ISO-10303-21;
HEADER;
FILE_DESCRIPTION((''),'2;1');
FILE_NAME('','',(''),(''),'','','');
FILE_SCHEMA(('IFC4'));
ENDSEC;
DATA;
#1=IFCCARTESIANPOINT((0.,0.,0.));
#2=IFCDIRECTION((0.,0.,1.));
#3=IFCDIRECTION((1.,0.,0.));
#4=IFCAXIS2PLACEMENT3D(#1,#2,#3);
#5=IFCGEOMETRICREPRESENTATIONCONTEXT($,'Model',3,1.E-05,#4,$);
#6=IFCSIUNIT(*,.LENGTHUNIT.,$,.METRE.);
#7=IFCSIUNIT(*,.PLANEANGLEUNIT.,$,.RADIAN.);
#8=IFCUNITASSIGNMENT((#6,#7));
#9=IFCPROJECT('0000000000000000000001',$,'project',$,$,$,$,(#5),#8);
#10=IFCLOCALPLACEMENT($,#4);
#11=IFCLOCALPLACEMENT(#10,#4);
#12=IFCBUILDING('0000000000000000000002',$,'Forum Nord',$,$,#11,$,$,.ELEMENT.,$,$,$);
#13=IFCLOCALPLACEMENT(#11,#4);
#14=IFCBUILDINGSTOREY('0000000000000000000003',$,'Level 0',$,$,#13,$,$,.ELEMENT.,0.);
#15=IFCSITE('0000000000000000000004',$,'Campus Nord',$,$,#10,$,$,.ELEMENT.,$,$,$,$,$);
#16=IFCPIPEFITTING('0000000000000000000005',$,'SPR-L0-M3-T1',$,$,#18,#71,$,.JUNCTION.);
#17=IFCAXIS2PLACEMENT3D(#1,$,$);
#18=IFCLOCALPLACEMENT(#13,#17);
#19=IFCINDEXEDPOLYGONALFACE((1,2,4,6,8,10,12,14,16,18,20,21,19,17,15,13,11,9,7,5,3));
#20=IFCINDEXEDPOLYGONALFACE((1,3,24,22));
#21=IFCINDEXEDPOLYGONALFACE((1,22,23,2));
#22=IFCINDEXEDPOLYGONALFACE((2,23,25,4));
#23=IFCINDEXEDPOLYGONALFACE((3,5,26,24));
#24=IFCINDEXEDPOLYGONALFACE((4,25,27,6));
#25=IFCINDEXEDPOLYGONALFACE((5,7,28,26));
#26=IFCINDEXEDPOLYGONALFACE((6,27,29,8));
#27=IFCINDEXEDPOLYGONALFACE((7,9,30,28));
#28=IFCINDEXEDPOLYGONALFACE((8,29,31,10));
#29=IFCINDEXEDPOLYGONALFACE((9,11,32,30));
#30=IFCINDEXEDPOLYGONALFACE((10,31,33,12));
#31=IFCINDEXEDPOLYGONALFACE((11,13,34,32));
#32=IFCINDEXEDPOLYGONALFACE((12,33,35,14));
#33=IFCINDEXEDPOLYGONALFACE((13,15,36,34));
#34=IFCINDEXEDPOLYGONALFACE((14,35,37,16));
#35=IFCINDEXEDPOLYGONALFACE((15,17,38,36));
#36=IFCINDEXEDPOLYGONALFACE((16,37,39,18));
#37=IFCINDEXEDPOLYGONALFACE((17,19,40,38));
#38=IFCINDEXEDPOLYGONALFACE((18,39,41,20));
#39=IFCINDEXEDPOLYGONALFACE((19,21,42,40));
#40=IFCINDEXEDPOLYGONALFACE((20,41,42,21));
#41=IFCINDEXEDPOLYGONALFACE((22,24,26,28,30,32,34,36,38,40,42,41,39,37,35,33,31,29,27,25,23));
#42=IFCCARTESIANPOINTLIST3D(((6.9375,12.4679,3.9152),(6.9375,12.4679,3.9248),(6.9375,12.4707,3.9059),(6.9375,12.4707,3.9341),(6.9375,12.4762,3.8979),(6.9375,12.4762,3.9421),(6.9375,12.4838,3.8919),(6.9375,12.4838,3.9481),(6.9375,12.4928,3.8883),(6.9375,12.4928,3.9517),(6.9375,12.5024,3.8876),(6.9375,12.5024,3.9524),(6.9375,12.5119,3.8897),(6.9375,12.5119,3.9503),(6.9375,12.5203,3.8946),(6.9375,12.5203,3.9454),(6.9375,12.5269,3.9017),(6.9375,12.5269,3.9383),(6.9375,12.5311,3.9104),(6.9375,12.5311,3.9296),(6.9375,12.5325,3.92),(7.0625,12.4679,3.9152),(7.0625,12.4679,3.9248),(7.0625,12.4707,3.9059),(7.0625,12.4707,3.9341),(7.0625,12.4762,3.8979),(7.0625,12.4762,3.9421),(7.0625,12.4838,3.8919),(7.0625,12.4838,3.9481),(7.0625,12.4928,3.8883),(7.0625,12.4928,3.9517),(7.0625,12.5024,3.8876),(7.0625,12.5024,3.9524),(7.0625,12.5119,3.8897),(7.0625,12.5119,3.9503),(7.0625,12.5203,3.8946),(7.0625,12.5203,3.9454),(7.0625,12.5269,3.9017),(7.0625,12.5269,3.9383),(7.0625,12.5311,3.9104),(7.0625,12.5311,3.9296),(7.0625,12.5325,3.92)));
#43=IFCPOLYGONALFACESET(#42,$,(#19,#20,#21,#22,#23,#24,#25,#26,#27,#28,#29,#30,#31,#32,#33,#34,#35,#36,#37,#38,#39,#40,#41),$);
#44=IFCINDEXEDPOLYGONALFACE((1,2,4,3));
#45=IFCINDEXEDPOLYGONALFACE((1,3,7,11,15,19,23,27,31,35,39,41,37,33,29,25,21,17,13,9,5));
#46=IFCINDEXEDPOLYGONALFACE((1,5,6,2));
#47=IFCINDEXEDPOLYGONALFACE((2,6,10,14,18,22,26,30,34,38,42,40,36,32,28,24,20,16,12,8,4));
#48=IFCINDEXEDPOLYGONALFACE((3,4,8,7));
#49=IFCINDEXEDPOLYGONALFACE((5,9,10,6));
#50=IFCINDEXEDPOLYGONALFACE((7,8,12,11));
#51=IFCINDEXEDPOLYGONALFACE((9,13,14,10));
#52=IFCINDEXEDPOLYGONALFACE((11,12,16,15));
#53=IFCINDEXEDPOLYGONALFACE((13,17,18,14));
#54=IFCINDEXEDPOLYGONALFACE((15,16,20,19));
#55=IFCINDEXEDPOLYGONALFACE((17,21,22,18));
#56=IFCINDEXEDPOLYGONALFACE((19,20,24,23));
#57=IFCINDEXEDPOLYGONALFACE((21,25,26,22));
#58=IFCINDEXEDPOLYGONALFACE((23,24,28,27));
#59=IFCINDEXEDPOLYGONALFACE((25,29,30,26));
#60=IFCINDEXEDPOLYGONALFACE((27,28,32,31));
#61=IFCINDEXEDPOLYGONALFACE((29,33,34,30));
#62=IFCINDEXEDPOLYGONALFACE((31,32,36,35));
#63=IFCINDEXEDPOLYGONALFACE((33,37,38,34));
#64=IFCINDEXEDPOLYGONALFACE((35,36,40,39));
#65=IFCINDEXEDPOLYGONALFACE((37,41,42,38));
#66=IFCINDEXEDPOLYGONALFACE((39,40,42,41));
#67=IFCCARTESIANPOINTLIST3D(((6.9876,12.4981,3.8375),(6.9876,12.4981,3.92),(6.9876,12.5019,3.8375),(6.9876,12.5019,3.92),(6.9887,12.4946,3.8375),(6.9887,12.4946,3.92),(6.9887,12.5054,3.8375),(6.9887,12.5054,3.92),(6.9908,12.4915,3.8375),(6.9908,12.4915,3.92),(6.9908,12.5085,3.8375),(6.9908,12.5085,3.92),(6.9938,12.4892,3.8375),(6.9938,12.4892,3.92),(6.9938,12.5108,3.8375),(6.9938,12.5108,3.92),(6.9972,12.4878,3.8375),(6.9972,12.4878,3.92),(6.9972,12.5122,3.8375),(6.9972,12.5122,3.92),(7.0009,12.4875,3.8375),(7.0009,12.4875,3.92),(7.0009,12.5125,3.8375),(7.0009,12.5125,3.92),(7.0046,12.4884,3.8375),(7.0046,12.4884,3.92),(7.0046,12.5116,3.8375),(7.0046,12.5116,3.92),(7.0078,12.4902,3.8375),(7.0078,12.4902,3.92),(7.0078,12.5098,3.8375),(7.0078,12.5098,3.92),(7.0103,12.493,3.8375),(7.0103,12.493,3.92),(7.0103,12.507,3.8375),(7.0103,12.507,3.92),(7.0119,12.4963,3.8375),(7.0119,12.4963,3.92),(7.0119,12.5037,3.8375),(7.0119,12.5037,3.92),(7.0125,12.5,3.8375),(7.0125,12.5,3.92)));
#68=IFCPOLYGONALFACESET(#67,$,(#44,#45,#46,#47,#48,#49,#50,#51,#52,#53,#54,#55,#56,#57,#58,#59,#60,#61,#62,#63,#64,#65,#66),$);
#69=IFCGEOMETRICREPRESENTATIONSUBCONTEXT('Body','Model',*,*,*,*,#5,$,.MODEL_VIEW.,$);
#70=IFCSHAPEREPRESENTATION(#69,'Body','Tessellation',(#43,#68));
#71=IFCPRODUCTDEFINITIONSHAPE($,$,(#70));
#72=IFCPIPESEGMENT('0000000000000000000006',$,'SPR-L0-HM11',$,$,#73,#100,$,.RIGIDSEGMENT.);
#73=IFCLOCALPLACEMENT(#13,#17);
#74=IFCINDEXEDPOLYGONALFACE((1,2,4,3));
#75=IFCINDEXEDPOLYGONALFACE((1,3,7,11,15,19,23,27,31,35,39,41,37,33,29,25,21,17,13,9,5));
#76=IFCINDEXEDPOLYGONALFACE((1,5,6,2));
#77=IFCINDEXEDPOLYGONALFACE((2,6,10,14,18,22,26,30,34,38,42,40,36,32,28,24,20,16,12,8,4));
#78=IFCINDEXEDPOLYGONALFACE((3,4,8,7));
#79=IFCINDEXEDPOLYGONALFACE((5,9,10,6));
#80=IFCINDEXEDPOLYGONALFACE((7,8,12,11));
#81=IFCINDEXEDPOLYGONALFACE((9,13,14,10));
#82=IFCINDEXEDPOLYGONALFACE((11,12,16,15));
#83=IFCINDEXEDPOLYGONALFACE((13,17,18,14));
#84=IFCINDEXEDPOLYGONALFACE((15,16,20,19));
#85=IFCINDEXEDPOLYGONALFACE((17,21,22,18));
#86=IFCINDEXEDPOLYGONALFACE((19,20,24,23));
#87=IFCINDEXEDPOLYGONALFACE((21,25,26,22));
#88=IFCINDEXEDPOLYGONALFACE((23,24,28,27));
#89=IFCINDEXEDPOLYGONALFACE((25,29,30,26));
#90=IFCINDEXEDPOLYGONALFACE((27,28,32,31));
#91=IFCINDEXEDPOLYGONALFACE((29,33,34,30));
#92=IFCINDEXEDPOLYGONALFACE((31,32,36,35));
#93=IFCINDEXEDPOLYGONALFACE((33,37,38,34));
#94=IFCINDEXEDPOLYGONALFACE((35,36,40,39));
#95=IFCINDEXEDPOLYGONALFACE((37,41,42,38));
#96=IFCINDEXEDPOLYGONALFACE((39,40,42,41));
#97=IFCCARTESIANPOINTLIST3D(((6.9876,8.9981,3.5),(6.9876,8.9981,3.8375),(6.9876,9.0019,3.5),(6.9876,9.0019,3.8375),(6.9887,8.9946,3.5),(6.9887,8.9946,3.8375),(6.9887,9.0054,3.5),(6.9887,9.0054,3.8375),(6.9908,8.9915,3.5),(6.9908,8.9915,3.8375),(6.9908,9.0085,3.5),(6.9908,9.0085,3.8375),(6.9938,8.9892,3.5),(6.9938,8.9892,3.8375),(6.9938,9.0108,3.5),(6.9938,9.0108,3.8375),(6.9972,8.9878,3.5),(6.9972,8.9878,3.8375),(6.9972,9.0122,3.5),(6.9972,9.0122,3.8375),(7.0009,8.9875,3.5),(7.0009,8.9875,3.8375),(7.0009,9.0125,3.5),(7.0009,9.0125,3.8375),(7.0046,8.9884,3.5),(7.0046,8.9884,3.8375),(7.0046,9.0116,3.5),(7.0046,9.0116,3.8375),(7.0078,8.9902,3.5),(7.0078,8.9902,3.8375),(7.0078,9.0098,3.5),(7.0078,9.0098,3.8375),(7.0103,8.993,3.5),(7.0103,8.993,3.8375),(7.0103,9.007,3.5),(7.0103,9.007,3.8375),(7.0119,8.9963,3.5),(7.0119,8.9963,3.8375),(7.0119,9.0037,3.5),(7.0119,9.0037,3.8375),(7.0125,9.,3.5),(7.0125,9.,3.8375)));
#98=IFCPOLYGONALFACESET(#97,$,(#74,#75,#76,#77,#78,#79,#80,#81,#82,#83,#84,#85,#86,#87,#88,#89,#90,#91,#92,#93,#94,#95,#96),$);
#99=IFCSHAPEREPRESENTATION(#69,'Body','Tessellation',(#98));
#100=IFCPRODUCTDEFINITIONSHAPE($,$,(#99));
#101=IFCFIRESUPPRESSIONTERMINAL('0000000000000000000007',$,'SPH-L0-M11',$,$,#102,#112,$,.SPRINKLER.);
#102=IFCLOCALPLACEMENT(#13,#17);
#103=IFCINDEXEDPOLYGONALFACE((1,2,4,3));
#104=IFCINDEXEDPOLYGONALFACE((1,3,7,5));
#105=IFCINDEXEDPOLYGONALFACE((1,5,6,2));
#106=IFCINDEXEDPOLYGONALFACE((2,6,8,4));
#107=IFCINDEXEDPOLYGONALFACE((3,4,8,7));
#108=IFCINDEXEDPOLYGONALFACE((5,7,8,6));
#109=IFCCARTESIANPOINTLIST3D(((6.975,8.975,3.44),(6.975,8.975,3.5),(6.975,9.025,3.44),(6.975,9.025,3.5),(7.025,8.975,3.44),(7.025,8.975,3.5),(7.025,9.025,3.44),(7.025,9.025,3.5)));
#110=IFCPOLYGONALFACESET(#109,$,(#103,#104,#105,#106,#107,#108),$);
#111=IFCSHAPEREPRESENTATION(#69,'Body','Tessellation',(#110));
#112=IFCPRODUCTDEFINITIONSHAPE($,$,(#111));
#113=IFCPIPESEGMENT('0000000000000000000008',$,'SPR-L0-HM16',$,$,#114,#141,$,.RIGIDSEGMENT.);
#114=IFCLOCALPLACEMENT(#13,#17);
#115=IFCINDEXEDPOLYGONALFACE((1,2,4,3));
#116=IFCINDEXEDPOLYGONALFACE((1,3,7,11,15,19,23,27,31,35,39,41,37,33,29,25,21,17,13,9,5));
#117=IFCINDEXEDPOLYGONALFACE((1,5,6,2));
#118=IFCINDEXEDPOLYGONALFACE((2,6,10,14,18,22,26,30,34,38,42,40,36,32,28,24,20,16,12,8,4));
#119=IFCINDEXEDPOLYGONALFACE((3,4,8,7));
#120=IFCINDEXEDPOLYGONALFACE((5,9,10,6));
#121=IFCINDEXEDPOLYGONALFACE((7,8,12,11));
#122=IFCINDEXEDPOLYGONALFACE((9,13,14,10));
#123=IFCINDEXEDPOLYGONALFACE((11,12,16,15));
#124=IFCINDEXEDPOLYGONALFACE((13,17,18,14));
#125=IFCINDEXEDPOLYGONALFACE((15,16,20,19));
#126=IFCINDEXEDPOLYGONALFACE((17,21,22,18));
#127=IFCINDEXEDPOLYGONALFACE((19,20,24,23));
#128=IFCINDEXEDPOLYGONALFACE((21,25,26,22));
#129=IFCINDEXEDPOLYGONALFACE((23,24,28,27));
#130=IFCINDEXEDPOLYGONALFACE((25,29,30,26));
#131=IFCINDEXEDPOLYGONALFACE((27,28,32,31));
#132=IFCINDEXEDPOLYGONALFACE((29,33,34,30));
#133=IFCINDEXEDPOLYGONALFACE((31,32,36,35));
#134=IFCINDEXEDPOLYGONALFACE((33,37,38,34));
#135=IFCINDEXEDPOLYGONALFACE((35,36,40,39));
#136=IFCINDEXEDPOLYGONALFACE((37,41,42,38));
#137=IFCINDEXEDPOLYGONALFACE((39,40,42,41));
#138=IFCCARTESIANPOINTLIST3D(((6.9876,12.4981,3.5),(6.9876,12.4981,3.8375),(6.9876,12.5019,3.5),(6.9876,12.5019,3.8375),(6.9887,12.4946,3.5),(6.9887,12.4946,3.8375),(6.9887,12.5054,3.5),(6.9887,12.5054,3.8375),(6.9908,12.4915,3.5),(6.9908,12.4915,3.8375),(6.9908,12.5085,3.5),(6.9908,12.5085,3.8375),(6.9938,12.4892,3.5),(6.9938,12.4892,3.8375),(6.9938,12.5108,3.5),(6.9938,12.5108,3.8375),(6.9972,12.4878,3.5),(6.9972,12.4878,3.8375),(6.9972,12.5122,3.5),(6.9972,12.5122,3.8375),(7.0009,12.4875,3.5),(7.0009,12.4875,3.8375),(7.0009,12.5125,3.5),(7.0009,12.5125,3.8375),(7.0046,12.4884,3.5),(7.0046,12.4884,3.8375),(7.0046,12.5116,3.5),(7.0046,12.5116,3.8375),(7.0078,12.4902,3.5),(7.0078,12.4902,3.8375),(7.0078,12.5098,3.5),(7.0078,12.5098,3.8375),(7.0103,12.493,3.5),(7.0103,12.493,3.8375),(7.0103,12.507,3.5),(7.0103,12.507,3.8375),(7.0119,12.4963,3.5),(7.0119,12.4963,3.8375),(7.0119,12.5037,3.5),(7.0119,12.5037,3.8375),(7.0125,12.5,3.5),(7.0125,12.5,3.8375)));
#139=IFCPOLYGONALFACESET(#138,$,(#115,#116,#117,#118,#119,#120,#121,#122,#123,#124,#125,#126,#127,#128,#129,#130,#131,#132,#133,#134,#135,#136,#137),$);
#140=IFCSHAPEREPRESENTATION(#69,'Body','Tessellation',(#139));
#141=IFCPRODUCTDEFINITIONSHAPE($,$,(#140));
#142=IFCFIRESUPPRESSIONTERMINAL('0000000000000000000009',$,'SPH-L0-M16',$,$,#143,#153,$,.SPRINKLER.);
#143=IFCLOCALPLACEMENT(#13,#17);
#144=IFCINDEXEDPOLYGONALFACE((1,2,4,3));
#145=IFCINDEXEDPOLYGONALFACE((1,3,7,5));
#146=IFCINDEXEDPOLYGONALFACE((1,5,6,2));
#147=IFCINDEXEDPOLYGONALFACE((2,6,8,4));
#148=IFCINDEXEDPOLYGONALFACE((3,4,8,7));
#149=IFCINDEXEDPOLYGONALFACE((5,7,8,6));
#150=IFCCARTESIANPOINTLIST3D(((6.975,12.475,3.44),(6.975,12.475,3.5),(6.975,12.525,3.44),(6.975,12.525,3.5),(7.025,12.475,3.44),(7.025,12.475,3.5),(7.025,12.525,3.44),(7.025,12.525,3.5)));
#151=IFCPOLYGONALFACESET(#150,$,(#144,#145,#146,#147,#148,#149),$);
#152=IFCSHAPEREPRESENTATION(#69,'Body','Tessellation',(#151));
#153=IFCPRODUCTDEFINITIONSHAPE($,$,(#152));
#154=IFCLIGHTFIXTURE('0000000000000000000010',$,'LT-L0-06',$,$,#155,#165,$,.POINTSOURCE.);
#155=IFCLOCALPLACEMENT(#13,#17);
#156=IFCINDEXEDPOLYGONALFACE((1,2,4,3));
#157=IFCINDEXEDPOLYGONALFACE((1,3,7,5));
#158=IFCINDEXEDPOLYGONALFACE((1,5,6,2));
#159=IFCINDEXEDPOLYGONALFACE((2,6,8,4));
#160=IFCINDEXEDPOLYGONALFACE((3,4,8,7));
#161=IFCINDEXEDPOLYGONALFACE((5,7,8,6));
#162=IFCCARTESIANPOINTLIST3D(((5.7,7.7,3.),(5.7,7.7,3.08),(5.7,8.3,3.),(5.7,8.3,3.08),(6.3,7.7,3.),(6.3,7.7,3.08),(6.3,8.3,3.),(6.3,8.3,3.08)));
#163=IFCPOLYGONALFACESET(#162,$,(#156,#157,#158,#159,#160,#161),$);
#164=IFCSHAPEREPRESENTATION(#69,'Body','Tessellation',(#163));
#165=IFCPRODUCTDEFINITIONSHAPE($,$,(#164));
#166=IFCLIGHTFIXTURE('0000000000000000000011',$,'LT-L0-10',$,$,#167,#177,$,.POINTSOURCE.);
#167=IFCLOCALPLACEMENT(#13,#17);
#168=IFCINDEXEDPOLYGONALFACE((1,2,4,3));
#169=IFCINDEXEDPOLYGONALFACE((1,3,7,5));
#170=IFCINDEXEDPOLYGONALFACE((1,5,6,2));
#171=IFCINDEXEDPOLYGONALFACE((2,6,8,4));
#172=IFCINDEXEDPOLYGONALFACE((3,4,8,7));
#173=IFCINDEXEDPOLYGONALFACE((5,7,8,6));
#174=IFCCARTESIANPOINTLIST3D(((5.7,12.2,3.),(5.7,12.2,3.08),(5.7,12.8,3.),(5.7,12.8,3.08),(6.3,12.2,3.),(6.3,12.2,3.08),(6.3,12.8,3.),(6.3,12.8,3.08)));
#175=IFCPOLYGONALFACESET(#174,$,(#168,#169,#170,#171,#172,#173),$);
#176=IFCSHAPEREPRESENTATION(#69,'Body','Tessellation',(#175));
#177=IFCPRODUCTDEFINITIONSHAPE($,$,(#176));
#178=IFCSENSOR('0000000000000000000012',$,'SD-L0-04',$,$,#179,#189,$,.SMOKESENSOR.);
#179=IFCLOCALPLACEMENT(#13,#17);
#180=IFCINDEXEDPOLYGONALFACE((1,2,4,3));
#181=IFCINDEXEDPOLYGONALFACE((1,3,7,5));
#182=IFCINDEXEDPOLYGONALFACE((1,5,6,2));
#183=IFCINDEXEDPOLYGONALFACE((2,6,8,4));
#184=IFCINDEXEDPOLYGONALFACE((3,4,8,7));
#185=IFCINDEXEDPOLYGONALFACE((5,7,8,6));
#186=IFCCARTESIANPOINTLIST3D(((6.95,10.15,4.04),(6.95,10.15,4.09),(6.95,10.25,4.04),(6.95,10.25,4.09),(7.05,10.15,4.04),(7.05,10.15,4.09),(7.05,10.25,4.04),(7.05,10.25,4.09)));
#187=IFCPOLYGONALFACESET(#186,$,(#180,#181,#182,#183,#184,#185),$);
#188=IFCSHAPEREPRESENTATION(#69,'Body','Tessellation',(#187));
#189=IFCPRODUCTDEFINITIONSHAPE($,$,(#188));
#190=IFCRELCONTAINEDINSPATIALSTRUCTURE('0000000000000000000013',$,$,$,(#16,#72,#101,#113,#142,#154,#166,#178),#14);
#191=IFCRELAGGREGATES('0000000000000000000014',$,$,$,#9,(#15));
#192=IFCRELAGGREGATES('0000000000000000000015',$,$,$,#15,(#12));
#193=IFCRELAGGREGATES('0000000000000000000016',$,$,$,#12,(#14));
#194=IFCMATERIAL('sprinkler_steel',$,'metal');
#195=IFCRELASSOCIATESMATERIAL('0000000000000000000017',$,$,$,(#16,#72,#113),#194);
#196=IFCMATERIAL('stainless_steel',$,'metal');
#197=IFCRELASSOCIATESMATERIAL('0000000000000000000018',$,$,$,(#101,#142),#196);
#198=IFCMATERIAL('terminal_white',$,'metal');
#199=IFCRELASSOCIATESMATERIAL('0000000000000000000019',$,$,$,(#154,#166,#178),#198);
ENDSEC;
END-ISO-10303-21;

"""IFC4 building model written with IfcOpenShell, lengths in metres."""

from ifc_helpers import new_model, si_unit, frame, origin_with_axes, origin_2d_with_axis, place, context, subcontext, project, spatial, rectangle, circle, extrude, material, element, save


model = new_model("IFC4")

# Units and contexts
model_context = context("Model", 3, precision=1e-05, world=origin_with_axes())
body_context = subcontext(model_context, "Body", "Model", "MODEL_VIEW")
ifc_project = project(units=[si_unit("LENGTHUNIT", "METRE"), si_unit("PLANEANGLEUNIT", "RADIAN")], contexts=[model_context])

# Site, building, storey
site_placement = place(None, origin_with_axes())
site = spatial("IfcSite", under=ifc_project, at=site_placement, Name="Campus Nord", CompositionType="ELEMENT")
building_placement = place(site_placement, origin_with_axes())
building = spatial("IfcBuilding", under=site, at=building_placement, Name="Forum Nord", CompositionType="ELEMENT")
storey_placement = place(building_placement, origin_with_axes())
storey = spatial("IfcBuildingStorey", under=building, at=storey_placement, Name="Level 0", CompositionType="ELEMENT", Elevation=0.0)

# Shared definitions
ifc_material_1 = material(Name="terminal_white", Category="metal")

# Shared definitions
ifc_material_2 = material(Name="sprinkler_steel", Category="metal")

# Pipe fitting
pipe_fitting_1_placement = place(storey_placement, frame((6.9375, 12.5, 3.92), z_axis=(1.0, 0.0, 0.0), x_axis=(0.0, 1.0, 0.0)))
element("IfcPipeFitting", 1, at=pipe_fitting_1_placement, inside=storey, material=ifc_material_2, Name="SPR-L0-M3-T1", PredefinedType="JUNCTION", context=body_context, shape_type="SweptSolid", body=[
    extrude(circle(Radius=0.0325, at=origin_2d_with_axis()), origin_with_axes(), (0.0, 0.0, 1.0), 0.125),
    extrude(circle(Radius=0.0125, at=origin_2d_with_axis()), frame((0.0, 0.0, 0.0625), z_axis=(0.0, -1.0, 0.0), x_axis=(0.0, 0.0, 1.0)), (0.0, 0.0, 1.0), 0.0825),
])

# Pipe segment
pipe_segment_1_placement = place(storey_placement, frame((7.0, 9.0, 3.8375), z_axis=(0.0, 0.0, -1.0), x_axis=(1.0, 0.0, 0.0)))
element("IfcPipeSegment", 2, at=pipe_segment_1_placement, inside=storey, material=ifc_material_2, Name="SPR-L0-HM11", PredefinedType="RIGIDSEGMENT", context=body_context, shape_type="SweptSolid", body=[
    extrude(circle(Radius=0.0125, at=origin_2d_with_axis()), origin_with_axes(), (0.0, 0.0, 1.0), 0.3375),
])

# Fire suppression terminal
ifc_material_3 = material(Name="stainless_steel", Category="metal")
fire_suppression_terminal_1_placement = place(storey_placement, frame((7.0, 9.0, 3.44), z_axis=(0.0, 0.0, 1.0), x_axis=(1.0, 0.0, 0.0)))
element("IfcFireSuppressionTerminal", 3, at=fire_suppression_terminal_1_placement, inside=storey, material=ifc_material_3, Name="SPH-L0-M11", PredefinedType="SPRINKLER", context=body_context, shape_type="SweptSolid", body=[
    extrude(rectangle(XDim=0.05, YDim=0.05, at=origin_2d_with_axis()), origin_with_axes(), (0.0, 0.0, 1.0), 0.06),
])

# Pipe segment
pipe_segment_2_placement = place(storey_placement, frame((7.0, 12.5, 3.8375), z_axis=(0.0, 0.0, -1.0), x_axis=(1.0, 0.0, 0.0)))
element("IfcPipeSegment", 4, at=pipe_segment_2_placement, inside=storey, material=ifc_material_2, Name="SPR-L0-HM16", PredefinedType="RIGIDSEGMENT", context=body_context, shape_type="SweptSolid", body=[
    extrude(circle(Radius=0.0125, at=origin_2d_with_axis()), origin_with_axes(), (0.0, 0.0, 1.0), 0.3375),
])

# Fire suppression terminal
fire_suppression_terminal_2_placement = place(storey_placement, frame((7.0, 12.5, 3.44), z_axis=(0.0, 0.0, 1.0), x_axis=(1.0, 0.0, 0.0)))
element("IfcFireSuppressionTerminal", 5, at=fire_suppression_terminal_2_placement, inside=storey, material=ifc_material_3, Name="SPH-L0-M16", PredefinedType="SPRINKLER", context=body_context, shape_type="SweptSolid", body=[
    extrude(rectangle(XDim=0.05, YDim=0.05, at=origin_2d_with_axis()), origin_with_axes(), (0.0, 0.0, 1.0), 0.06),
])

# Light fixtures
for number, where, z_axis, x_axis, name in (
    (6, (6.0, 8.0, 3.0), (0.0, 0.0, 1.0), (1.0, 0.0, 0.0), "LT-L0-06"),
    (7, (6.0, 12.5, 3.0), (0.0, 0.0, 1.0), (1.0, 0.0, 0.0), "LT-L0-10"),
):
    element("IfcLightFixture", number, at=place(storey_placement, frame(where, z_axis=z_axis, x_axis=x_axis)), inside=storey, material=ifc_material_1, Name=name, PredefinedType="POINTSOURCE", context=body_context, shape_type="SweptSolid", body=[
        extrude(rectangle(XDim=0.6, YDim=0.6, at=origin_2d_with_axis()), origin_with_axes(), (0.0, 0.0, 1.0), 0.08),
    ])

# Sensor
sensor_placement = place(storey_placement, frame((7.0, 10.2, 4.04), z_axis=(0.0, 0.0, 1.0), x_axis=(1.0, 0.0, 0.0)))
element("IfcSensor", 8, at=sensor_placement, inside=storey, material=ifc_material_1, Name="SD-L0-04", PredefinedType="SMOKESENSOR", context=body_context, shape_type="SweptSolid", body=[
    extrude(rectangle(XDim=0.1, YDim=0.1, at=origin_2d_with_axis()), origin_with_axes(), (0.0, 0.0, 1.0), 0.05),
])

save(model, "model.ifc")
